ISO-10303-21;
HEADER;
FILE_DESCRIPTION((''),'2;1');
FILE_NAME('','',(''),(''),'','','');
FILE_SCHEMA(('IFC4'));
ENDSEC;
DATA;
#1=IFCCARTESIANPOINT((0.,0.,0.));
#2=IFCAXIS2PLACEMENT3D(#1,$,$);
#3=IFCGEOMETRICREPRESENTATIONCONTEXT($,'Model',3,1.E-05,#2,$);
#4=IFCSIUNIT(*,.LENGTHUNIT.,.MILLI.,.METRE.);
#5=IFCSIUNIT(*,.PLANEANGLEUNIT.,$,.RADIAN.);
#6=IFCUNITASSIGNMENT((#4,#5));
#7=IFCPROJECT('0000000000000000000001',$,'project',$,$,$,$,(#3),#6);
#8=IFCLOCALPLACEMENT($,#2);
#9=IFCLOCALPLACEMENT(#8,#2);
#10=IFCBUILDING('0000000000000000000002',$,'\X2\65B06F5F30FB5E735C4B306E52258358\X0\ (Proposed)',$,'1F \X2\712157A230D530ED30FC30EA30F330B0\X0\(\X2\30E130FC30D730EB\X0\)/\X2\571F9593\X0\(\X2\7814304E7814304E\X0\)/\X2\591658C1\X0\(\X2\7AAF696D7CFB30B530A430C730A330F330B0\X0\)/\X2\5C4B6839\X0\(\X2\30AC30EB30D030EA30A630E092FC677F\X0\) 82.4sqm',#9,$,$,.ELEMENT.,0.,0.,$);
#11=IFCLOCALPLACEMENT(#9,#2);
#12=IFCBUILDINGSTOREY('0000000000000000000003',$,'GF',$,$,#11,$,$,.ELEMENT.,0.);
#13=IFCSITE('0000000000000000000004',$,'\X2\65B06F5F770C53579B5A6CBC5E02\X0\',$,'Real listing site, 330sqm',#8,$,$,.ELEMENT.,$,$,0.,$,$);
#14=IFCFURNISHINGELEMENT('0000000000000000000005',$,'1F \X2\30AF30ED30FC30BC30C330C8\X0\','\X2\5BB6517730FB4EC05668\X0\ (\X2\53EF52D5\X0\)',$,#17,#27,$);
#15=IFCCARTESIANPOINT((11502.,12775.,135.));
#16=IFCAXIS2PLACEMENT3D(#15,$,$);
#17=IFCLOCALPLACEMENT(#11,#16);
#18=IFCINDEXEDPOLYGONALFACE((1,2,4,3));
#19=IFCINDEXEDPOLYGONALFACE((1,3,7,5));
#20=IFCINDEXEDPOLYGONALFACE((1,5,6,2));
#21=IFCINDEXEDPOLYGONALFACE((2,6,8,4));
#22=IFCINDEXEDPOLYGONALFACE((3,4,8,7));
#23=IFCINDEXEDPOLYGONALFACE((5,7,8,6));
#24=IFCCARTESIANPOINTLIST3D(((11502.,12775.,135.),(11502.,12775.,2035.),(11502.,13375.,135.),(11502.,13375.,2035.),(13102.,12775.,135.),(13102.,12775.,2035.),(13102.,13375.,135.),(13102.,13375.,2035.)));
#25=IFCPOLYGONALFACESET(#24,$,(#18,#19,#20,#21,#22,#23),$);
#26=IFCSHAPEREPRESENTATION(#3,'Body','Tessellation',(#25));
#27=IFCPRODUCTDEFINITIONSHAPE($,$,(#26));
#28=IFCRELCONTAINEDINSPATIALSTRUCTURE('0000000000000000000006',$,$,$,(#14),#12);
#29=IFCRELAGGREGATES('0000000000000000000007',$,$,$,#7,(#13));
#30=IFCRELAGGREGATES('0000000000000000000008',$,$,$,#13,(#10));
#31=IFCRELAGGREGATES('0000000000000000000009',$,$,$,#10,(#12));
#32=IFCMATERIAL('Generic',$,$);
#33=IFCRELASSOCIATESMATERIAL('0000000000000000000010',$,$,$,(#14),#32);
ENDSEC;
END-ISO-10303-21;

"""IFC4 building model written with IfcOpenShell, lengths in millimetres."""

from ifc_helpers import new_model, si_unit, frame, frame_2d, origin, place, context, project, spatial, rectangle, extrude, material, element, save


model = new_model("IFC4")

# Units and contexts
model_context = context("Model", 3, precision=1e-05, world=origin())
ifc_project = project(units=[si_unit("LENGTHUNIT", "METRE", prefix="MILLI"), si_unit("PLANEANGLEUNIT", "RADIAN")], contexts=[model_context])

# Site, building, storey
site_placement = place(None, origin())
site = spatial("IfcSite", under=ifc_project, at=site_placement, Name="新潟県南魚沼市", ObjectType="Real listing site, 330sqm", CompositionType="ELEMENT", RefElevation=0.0)
building_placement = place(site_placement, origin())
building = spatial("IfcBuilding", under=site, at=building_placement, Name="新潟・平屋の別荘 (Proposed)", ObjectType="1F 無垢フローリング(メープル)/土間(研ぎ研ぎ)/外壁(窯業系サイディング)/屋根(ガルバリウム鋼板) 82.4sqm", CompositionType="ELEMENT", ElevationOfRefHeight=0.0, ElevationOfTerrain=0.0)
storey_placement = place(building_placement, origin())
storey = spatial("IfcBuildingStorey", under=building, at=storey_placement, Name="GF", CompositionType="ELEMENT", Elevation=0.0)

# Shared definitions
ifc_material_1 = material(Name="Generic")

# Furnishing element
furnishing_placement = place(storey_placement, frame((11502.0, 12775.0, 135.0)))
element("IfcFurnishingElement", 1, at=furnishing_placement, inside=storey, material=ifc_material_1, Name="1F クローゼット", Description="家具・什器 (可動)", context=model_context, shape_type="SweptSolid", body=[
    extrude(rectangle(XDim=1600.0, YDim=600.0, at=frame_2d((800.0, 300.0))), frame((11502.0, 12775.0, 135.0)), (0.0, 0.0, 1.0), 1900.0),
])

save(model, "model.ifc")
